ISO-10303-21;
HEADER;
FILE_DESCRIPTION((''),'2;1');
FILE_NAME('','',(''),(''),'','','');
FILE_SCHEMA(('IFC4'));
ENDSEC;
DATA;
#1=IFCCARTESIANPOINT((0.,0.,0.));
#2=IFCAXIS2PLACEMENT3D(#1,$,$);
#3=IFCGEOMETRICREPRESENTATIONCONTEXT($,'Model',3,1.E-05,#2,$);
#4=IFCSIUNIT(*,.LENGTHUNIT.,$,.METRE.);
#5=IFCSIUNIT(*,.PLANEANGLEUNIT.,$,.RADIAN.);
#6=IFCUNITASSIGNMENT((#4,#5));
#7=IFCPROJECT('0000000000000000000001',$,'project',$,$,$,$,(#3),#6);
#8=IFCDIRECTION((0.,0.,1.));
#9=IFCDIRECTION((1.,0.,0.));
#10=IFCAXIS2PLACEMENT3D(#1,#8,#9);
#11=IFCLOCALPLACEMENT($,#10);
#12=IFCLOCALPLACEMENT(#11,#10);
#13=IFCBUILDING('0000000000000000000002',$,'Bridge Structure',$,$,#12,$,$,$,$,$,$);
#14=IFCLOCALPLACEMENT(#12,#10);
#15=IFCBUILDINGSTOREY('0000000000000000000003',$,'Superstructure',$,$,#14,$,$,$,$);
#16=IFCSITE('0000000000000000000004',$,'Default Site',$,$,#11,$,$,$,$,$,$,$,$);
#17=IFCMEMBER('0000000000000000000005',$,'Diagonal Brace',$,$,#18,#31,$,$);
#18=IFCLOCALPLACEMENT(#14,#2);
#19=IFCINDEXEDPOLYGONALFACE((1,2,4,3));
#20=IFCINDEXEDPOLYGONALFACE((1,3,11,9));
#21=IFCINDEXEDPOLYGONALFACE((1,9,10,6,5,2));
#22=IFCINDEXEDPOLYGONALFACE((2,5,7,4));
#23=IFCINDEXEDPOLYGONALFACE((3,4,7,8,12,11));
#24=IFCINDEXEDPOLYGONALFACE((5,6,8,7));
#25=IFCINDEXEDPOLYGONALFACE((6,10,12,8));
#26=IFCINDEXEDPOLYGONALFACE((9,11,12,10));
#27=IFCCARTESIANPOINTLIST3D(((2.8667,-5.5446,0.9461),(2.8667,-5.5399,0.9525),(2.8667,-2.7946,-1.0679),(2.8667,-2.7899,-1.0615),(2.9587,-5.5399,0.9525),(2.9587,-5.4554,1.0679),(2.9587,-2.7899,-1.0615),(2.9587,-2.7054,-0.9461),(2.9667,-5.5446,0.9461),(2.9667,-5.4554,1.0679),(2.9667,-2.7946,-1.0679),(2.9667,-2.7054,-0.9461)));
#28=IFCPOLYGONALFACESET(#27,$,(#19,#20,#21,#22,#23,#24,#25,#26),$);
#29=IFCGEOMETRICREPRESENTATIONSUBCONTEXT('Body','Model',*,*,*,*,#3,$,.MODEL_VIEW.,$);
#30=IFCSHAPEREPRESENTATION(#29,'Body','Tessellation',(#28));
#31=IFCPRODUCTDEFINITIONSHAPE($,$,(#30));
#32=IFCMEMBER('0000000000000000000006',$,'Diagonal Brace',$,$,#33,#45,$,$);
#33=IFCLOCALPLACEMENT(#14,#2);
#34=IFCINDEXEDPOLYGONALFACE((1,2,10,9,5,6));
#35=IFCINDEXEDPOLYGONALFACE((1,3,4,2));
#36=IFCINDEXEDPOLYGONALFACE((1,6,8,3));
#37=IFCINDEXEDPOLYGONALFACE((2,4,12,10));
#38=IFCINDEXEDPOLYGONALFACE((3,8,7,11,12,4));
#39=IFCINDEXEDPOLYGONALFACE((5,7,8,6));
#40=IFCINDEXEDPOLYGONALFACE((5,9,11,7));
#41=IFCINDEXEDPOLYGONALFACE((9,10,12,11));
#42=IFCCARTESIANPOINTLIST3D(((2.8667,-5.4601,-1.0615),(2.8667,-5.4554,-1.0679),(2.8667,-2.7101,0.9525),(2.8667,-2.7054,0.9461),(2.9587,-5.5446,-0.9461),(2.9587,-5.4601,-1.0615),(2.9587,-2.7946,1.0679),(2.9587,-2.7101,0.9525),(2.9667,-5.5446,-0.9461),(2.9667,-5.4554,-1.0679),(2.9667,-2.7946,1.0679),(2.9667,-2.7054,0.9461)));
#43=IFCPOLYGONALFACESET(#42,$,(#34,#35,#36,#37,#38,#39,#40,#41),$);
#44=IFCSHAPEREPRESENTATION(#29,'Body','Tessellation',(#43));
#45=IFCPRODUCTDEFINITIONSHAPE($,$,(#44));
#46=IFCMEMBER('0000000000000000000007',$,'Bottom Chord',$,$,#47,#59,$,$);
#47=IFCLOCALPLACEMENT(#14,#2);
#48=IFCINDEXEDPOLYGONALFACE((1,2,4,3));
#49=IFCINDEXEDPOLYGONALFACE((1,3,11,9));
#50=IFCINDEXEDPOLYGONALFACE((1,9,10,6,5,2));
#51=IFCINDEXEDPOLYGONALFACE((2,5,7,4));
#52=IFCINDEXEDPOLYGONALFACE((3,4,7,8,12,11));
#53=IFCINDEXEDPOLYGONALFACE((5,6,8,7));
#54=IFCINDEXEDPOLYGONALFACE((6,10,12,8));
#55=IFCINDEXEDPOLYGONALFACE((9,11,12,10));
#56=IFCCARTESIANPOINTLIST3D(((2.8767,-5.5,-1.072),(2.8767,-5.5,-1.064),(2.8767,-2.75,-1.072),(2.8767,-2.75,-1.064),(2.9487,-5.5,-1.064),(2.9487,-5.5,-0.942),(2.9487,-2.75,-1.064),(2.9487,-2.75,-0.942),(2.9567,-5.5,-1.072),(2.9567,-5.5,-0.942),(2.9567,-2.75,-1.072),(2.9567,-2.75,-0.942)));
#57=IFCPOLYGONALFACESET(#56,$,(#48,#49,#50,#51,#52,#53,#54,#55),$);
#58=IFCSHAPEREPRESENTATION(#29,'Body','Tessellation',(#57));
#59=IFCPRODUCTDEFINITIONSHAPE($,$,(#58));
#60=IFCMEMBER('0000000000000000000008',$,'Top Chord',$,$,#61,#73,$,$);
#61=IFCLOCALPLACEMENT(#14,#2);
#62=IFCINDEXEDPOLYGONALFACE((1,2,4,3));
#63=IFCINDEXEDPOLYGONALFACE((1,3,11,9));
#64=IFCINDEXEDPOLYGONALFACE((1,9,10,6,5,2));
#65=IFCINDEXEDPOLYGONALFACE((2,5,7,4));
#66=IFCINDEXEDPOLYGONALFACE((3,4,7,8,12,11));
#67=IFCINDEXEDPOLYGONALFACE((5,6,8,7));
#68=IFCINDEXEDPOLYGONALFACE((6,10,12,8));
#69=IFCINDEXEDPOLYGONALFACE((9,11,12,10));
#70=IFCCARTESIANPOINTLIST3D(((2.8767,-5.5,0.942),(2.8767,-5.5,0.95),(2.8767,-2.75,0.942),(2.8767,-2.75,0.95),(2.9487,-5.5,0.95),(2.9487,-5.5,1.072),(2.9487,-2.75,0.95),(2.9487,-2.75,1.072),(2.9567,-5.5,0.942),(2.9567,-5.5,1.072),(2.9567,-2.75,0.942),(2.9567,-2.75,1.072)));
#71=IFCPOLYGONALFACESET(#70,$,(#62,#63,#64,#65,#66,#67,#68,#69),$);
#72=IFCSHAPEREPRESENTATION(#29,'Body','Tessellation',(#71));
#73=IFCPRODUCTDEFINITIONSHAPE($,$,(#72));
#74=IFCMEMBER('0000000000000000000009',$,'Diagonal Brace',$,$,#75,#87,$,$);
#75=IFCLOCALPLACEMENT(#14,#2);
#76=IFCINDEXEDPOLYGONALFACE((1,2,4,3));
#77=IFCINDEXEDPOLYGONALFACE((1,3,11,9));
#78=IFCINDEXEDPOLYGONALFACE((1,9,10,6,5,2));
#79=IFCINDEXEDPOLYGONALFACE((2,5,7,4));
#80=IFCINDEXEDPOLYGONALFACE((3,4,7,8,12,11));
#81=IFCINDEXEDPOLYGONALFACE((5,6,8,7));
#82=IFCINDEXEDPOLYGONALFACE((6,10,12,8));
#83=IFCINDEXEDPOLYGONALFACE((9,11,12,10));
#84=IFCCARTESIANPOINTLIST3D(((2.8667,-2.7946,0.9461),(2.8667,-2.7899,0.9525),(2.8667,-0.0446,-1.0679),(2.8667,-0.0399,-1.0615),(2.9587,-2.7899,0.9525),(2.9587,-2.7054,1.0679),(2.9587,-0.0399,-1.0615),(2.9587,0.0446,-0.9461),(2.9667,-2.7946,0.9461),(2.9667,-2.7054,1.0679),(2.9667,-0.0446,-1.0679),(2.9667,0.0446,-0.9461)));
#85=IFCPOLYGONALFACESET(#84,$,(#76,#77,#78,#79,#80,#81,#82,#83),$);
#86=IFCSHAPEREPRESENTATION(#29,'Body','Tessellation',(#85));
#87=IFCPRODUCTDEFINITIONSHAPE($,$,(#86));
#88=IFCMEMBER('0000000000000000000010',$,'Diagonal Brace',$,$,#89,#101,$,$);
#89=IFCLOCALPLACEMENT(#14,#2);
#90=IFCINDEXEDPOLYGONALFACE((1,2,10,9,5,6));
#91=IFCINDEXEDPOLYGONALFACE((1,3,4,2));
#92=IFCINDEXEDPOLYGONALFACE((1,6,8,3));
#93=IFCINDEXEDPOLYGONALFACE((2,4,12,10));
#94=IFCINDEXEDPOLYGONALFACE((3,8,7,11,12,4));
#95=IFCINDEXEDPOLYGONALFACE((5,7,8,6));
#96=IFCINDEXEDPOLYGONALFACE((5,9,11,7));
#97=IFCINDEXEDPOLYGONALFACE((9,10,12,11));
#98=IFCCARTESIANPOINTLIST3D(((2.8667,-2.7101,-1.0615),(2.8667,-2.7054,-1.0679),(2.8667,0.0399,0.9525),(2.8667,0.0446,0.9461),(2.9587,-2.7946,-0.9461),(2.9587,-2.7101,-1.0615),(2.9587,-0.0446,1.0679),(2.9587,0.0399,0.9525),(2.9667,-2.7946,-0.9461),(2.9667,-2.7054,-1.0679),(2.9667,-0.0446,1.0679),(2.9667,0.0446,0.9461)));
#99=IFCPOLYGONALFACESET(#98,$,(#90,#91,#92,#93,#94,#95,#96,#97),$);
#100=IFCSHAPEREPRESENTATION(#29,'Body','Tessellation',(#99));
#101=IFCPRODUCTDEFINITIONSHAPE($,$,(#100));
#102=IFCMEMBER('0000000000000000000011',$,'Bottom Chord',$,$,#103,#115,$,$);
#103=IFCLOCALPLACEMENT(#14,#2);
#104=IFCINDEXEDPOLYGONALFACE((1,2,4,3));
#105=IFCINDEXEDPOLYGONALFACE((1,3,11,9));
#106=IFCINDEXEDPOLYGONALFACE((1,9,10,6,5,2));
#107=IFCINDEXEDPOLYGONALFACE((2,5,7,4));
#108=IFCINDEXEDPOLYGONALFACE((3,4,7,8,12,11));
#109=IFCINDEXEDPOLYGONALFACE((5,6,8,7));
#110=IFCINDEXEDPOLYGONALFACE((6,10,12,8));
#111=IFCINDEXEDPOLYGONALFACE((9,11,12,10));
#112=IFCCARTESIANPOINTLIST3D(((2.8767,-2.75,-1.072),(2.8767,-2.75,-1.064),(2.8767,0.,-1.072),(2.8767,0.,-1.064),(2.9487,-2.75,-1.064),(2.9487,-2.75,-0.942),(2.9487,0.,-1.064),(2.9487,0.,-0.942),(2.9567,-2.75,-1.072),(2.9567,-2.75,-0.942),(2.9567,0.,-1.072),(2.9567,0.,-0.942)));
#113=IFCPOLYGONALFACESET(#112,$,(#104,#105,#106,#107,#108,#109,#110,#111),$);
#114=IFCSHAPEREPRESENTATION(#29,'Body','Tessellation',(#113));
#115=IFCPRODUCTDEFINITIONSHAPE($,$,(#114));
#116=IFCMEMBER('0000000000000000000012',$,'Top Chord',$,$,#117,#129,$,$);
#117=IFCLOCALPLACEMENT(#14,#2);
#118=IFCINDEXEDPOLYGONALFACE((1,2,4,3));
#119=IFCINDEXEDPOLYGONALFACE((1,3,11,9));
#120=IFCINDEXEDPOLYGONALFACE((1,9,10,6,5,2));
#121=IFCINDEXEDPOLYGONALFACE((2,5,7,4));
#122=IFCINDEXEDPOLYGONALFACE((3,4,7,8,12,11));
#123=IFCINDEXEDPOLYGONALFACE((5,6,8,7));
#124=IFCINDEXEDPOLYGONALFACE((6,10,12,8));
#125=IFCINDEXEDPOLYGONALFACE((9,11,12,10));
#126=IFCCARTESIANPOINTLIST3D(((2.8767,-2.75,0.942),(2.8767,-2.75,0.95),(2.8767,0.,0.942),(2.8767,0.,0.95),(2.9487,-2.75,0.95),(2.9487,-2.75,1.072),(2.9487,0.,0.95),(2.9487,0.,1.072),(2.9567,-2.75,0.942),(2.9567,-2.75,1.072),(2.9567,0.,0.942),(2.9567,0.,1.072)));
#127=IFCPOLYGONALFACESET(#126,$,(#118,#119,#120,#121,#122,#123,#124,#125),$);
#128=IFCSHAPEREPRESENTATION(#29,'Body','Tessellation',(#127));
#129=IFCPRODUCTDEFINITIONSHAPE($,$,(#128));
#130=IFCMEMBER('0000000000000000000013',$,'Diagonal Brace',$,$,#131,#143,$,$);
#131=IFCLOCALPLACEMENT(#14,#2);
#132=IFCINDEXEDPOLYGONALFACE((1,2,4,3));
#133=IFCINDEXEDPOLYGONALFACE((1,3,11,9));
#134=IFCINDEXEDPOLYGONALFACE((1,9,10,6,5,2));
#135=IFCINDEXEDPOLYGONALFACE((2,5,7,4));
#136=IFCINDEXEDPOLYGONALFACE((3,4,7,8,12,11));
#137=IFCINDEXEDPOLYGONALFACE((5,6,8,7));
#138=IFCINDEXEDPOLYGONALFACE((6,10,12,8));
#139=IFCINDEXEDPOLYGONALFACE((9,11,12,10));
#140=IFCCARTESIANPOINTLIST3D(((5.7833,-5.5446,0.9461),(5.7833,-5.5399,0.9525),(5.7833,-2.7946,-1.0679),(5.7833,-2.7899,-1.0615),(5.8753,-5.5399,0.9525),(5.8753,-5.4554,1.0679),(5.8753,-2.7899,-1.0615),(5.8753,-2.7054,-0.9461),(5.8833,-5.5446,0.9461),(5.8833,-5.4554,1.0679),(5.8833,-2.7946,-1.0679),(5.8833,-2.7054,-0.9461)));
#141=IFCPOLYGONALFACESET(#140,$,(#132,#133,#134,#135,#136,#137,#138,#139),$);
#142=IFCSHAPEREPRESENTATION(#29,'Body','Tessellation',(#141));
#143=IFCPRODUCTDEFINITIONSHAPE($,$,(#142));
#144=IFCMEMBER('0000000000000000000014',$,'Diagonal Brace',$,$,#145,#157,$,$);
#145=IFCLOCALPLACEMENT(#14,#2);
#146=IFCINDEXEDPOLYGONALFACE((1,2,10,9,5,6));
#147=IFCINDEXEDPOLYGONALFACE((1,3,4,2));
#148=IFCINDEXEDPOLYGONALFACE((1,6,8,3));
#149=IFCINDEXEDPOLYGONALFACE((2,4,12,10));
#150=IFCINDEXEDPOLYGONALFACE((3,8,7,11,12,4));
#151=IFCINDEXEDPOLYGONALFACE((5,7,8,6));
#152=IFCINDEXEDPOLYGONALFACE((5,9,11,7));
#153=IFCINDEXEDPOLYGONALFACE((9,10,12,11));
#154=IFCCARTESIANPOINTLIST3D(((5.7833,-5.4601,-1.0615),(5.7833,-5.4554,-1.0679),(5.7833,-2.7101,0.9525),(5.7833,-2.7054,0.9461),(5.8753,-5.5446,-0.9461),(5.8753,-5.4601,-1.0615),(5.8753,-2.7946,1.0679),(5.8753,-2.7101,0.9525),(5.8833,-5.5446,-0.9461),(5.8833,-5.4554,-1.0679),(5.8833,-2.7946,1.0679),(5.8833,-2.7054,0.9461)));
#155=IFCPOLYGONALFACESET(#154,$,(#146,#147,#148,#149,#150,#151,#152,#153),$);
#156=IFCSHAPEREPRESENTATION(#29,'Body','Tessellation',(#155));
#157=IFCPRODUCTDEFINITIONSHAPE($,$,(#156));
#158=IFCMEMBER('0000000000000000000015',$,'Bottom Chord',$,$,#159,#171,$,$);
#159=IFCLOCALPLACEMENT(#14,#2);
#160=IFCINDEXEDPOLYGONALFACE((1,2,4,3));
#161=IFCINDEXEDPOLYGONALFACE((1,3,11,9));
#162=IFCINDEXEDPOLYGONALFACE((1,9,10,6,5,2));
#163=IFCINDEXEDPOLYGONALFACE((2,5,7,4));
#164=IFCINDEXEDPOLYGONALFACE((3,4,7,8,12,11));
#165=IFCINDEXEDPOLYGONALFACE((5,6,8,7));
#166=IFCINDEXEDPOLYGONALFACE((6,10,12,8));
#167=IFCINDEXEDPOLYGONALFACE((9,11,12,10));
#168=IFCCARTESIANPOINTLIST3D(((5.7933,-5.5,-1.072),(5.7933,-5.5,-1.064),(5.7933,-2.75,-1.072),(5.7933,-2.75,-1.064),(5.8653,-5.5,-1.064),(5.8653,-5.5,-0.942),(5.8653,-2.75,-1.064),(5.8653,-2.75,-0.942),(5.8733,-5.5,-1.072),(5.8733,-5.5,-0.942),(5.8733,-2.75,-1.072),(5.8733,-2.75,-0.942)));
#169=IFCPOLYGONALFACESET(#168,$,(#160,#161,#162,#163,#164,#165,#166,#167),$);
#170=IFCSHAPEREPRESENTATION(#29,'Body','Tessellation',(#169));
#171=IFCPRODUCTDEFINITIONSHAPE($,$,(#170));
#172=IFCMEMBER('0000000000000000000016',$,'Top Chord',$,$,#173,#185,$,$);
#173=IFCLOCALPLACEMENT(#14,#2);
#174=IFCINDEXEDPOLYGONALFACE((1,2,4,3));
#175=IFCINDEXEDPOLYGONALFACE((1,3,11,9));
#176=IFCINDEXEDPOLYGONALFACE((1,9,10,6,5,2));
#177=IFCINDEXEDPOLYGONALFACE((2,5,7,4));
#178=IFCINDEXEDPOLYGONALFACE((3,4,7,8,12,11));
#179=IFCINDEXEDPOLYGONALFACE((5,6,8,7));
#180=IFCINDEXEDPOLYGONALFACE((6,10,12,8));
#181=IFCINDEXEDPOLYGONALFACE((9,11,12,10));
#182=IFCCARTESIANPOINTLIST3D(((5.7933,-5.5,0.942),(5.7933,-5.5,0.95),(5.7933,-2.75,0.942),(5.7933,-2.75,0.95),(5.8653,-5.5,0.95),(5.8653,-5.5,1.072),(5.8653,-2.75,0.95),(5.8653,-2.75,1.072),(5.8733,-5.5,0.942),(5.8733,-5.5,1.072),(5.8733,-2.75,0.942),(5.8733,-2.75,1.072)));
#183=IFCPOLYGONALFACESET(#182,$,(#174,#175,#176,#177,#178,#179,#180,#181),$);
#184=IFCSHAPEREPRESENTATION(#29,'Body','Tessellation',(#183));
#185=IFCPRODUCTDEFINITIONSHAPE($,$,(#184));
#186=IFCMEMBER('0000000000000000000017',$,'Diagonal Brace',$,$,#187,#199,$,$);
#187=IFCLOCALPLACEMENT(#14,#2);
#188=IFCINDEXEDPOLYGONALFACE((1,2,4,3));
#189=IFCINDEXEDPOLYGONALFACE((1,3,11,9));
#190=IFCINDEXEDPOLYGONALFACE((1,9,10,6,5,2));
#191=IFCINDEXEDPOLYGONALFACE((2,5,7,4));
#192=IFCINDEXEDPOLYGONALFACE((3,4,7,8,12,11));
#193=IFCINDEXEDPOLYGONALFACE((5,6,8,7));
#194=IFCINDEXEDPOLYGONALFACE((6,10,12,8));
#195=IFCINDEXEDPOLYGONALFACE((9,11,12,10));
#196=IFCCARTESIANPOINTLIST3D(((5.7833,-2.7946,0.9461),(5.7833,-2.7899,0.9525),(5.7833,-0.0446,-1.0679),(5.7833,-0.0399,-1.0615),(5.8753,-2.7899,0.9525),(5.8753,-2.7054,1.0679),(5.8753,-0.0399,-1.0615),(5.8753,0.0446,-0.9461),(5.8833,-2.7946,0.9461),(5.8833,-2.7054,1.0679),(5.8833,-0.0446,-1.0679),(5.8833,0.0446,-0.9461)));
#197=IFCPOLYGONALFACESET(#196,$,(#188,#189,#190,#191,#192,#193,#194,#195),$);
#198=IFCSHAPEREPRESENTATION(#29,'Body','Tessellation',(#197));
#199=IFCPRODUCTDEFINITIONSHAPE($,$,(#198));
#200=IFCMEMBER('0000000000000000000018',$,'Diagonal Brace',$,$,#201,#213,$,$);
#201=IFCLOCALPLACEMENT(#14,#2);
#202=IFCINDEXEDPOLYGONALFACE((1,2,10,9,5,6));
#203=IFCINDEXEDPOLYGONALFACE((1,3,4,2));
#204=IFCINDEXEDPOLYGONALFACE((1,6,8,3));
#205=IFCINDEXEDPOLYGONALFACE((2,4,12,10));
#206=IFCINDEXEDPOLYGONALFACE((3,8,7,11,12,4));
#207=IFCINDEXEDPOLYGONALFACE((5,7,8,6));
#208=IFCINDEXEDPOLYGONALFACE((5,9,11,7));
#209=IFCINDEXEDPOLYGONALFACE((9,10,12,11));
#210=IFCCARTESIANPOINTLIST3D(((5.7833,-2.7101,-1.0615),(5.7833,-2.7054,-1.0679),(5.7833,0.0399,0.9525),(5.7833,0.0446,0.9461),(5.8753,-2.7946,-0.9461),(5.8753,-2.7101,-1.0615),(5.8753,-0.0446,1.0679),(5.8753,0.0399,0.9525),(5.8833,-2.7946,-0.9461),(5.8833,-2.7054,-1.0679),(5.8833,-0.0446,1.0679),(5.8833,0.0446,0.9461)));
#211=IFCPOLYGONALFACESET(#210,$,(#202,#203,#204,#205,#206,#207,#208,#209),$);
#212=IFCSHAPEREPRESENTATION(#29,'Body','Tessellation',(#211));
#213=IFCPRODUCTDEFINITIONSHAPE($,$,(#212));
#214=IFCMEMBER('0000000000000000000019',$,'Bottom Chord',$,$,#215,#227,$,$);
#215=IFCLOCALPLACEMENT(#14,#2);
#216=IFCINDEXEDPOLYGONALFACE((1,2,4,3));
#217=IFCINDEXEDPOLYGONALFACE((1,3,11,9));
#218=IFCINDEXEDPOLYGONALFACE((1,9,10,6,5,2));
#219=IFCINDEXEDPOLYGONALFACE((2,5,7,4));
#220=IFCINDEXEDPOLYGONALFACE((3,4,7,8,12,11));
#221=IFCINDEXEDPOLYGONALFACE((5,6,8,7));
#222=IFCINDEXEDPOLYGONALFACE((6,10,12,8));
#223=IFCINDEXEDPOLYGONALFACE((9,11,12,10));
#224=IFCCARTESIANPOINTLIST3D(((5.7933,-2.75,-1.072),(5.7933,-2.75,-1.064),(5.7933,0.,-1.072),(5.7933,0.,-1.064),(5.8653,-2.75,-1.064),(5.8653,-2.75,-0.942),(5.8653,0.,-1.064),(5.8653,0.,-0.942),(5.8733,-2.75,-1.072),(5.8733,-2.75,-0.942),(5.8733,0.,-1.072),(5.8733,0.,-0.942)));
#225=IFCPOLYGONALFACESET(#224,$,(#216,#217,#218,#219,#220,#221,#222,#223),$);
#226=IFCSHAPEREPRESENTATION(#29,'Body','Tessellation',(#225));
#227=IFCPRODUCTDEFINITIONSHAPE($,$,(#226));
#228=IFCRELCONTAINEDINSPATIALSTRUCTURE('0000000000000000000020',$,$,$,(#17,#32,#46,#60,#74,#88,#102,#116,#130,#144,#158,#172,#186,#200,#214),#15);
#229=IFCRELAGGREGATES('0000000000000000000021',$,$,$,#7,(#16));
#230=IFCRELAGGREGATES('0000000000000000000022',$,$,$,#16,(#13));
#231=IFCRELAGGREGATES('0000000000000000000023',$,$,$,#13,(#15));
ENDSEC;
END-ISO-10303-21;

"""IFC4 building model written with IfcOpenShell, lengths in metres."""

from ifc_helpers import new_model, si_unit, frame, origin, origin_with_axes, origin_2d_with_axis, place, context, subcontext, project, spatial, l_section, extrude, element, save


model = new_model("IFC4")

# Units and contexts
model_context = context("Model", 3, precision=1e-05, world=origin())
body_context = subcontext(model_context, "Body", "Model", "MODEL_VIEW")
ifc_project = project(units=[si_unit("LENGTHUNIT", "METRE"), si_unit("PLANEANGLEUNIT", "RADIAN")], contexts=[model_context])

# Site, building, storey
site_placement = place(None, origin_with_axes())
site = spatial("IfcSite", under=ifc_project, at=site_placement, Name="Default Site")
building_placement = place(site_placement, origin_with_axes())
building = spatial("IfcBuilding", under=site, at=building_placement, Name="Bridge Structure")
storey_placement = place(building_placement, origin_with_axes())
storey = spatial("IfcBuildingStorey", under=building, at=storey_placement, Name="Superstructure")

# Members
for number, where, z_axis, x_axis, name in (
    (1, (2.9167, -5.5, 1.007), (0.0, 0.806778, -0.590855), (-1.0, 0.0, 0.0), "Diagonal Brace"),
    (2, (2.9167, -5.5, -1.007), (0.0, 0.806778, 0.590855), (-1.0, 0.0, 0.0), "Diagonal Brace"),
):
    element("IfcMember", number, at=place(storey_placement, frame(where, z_axis=z_axis, x_axis=x_axis)), inside=storey, Name=name, context=body_context, shape_type="SweptSolid", body=[
        extrude(l_section(Depth=0.151, Width=0.1, Thickness=0.008, at=origin_2d_with_axis()), origin_with_axes(), (0.0, 0.0, 1.0), 3.4086),
    ])
for number, where, z_axis, x_axis, name in (
    (3, (2.9167, -5.5, -1.007), (0.0, 1.0, 0.0), (-1.0, 0.0, 0.0), "Bottom Chord"),
    (4, (2.9167, -5.5, 1.007), (0.0, 1.0, 0.0), (-1.0, 0.0, 0.0), "Top Chord"),
):
    element("IfcMember", number, at=place(storey_placement, frame(where, z_axis=z_axis, x_axis=x_axis)), inside=storey, Name=name, context=body_context, shape_type="SweptSolid", body=[
        extrude(l_section(Depth=0.13, Width=0.08, Thickness=0.008, at=origin_2d_with_axis()), origin_with_axes(), (0.0, 0.0, 1.0), 2.75),
    ])
for number, where, z_axis, x_axis, name in (
    (5, (2.9167, -2.75, 1.007), (0.0, 0.806778, -0.590855), (-1.0, 0.0, 0.0), "Diagonal Brace"),
    (6, (2.9167, -2.75, -1.007), (0.0, 0.806778, 0.590855), (-1.0, 0.0, 0.0), "Diagonal Brace"),
):
    element("IfcMember", number, at=place(storey_placement, frame(where, z_axis=z_axis, x_axis=x_axis)), inside=storey, Name=name, context=body_context, shape_type="SweptSolid", body=[
        extrude(l_section(Depth=0.151, Width=0.1, Thickness=0.008, at=origin_2d_with_axis()), origin_with_axes(), (0.0, 0.0, 1.0), 3.4086),
    ])
for number, where, z_axis, x_axis, name in (
    (7, (2.9167, -2.75, -1.007), (0.0, 1.0, 0.0), (-1.0, 0.0, 0.0), "Bottom Chord"),
    (8, (2.9167, -2.75, 1.007), (0.0, 1.0, 0.0), (-1.0, 0.0, 0.0), "Top Chord"),
):
    element("IfcMember", number, at=place(storey_placement, frame(where, z_axis=z_axis, x_axis=x_axis)), inside=storey, Name=name, context=body_context, shape_type="SweptSolid", body=[
        extrude(l_section(Depth=0.13, Width=0.08, Thickness=0.008, at=origin_2d_with_axis()), origin_with_axes(), (0.0, 0.0, 1.0), 2.75),
    ])
for number, where, z_axis, x_axis, name in (
    (9, (5.8333, -5.5, 1.007), (0.0, 0.806778, -0.590855), (-1.0, 0.0, 0.0), "Diagonal Brace"),
    (10, (5.8333, -5.5, -1.007), (0.0, 0.806778, 0.590855), (-1.0, 0.0, 0.0), "Diagonal Brace"),
):
    element("IfcMember", number, at=place(storey_placement, frame(where, z_axis=z_axis, x_axis=x_axis)), inside=storey, Name=name, context=body_context, shape_type="SweptSolid", body=[
        extrude(l_section(Depth=0.151, Width=0.1, Thickness=0.008, at=origin_2d_with_axis()), origin_with_axes(), (0.0, 0.0, 1.0), 3.4086),
    ])
for number, where, z_axis, x_axis, name in (
    (11, (5.8333, -5.5, -1.007), (0.0, 1.0, 0.0), (-1.0, 0.0, 0.0), "Bottom Chord"),
    (12, (5.8333, -5.5, 1.007), (0.0, 1.0, 0.0), (-1.0, 0.0, 0.0), "Top Chord"),
):
    element("IfcMember", number, at=place(storey_placement, frame(where, z_axis=z_axis, x_axis=x_axis)), inside=storey, Name=name, context=body_context, shape_type="SweptSolid", body=[
        extrude(l_section(Depth=0.13, Width=0.08, Thickness=0.008, at=origin_2d_with_axis()), origin_with_axes(), (0.0, 0.0, 1.0), 2.75),
    ])
for number, where, z_axis, x_axis, name in (
    (13, (5.8333, -2.75, 1.007), (0.0, 0.806778, -0.590855), (-1.0, 0.0, 0.0), "Diagonal Brace"),
    (14, (5.8333, -2.75, -1.007), (0.0, 0.806778, 0.590855), (-1.0, 0.0, 0.0), "Diagonal Brace"),
):
    element("IfcMember", number, at=place(storey_placement, frame(where, z_axis=z_axis, x_axis=x_axis)), inside=storey, Name=name, context=body_context, shape_type="SweptSolid", body=[
        extrude(l_section(Depth=0.151, Width=0.1, Thickness=0.008, at=origin_2d_with_axis()), origin_with_axes(), (0.0, 0.0, 1.0), 3.4086),
    ])
for number, where, z_axis, x_axis, name in (
    (15, (5.8333, -2.75, -1.007), (0.0, 1.0, 0.0), (-1.0, 0.0, 0.0), "Bottom Chord"),
):
    element("IfcMember", number, at=place(storey_placement, frame(where, z_axis=z_axis, x_axis=x_axis)), inside=storey, Name=name, context=body_context, shape_type="SweptSolid", body=[
        extrude(l_section(Depth=0.13, Width=0.08, Thickness=0.008, at=origin_2d_with_axis()), origin_with_axes(), (0.0, 0.0, 1.0), 2.75),
    ])

save(model, "model.ifc")
